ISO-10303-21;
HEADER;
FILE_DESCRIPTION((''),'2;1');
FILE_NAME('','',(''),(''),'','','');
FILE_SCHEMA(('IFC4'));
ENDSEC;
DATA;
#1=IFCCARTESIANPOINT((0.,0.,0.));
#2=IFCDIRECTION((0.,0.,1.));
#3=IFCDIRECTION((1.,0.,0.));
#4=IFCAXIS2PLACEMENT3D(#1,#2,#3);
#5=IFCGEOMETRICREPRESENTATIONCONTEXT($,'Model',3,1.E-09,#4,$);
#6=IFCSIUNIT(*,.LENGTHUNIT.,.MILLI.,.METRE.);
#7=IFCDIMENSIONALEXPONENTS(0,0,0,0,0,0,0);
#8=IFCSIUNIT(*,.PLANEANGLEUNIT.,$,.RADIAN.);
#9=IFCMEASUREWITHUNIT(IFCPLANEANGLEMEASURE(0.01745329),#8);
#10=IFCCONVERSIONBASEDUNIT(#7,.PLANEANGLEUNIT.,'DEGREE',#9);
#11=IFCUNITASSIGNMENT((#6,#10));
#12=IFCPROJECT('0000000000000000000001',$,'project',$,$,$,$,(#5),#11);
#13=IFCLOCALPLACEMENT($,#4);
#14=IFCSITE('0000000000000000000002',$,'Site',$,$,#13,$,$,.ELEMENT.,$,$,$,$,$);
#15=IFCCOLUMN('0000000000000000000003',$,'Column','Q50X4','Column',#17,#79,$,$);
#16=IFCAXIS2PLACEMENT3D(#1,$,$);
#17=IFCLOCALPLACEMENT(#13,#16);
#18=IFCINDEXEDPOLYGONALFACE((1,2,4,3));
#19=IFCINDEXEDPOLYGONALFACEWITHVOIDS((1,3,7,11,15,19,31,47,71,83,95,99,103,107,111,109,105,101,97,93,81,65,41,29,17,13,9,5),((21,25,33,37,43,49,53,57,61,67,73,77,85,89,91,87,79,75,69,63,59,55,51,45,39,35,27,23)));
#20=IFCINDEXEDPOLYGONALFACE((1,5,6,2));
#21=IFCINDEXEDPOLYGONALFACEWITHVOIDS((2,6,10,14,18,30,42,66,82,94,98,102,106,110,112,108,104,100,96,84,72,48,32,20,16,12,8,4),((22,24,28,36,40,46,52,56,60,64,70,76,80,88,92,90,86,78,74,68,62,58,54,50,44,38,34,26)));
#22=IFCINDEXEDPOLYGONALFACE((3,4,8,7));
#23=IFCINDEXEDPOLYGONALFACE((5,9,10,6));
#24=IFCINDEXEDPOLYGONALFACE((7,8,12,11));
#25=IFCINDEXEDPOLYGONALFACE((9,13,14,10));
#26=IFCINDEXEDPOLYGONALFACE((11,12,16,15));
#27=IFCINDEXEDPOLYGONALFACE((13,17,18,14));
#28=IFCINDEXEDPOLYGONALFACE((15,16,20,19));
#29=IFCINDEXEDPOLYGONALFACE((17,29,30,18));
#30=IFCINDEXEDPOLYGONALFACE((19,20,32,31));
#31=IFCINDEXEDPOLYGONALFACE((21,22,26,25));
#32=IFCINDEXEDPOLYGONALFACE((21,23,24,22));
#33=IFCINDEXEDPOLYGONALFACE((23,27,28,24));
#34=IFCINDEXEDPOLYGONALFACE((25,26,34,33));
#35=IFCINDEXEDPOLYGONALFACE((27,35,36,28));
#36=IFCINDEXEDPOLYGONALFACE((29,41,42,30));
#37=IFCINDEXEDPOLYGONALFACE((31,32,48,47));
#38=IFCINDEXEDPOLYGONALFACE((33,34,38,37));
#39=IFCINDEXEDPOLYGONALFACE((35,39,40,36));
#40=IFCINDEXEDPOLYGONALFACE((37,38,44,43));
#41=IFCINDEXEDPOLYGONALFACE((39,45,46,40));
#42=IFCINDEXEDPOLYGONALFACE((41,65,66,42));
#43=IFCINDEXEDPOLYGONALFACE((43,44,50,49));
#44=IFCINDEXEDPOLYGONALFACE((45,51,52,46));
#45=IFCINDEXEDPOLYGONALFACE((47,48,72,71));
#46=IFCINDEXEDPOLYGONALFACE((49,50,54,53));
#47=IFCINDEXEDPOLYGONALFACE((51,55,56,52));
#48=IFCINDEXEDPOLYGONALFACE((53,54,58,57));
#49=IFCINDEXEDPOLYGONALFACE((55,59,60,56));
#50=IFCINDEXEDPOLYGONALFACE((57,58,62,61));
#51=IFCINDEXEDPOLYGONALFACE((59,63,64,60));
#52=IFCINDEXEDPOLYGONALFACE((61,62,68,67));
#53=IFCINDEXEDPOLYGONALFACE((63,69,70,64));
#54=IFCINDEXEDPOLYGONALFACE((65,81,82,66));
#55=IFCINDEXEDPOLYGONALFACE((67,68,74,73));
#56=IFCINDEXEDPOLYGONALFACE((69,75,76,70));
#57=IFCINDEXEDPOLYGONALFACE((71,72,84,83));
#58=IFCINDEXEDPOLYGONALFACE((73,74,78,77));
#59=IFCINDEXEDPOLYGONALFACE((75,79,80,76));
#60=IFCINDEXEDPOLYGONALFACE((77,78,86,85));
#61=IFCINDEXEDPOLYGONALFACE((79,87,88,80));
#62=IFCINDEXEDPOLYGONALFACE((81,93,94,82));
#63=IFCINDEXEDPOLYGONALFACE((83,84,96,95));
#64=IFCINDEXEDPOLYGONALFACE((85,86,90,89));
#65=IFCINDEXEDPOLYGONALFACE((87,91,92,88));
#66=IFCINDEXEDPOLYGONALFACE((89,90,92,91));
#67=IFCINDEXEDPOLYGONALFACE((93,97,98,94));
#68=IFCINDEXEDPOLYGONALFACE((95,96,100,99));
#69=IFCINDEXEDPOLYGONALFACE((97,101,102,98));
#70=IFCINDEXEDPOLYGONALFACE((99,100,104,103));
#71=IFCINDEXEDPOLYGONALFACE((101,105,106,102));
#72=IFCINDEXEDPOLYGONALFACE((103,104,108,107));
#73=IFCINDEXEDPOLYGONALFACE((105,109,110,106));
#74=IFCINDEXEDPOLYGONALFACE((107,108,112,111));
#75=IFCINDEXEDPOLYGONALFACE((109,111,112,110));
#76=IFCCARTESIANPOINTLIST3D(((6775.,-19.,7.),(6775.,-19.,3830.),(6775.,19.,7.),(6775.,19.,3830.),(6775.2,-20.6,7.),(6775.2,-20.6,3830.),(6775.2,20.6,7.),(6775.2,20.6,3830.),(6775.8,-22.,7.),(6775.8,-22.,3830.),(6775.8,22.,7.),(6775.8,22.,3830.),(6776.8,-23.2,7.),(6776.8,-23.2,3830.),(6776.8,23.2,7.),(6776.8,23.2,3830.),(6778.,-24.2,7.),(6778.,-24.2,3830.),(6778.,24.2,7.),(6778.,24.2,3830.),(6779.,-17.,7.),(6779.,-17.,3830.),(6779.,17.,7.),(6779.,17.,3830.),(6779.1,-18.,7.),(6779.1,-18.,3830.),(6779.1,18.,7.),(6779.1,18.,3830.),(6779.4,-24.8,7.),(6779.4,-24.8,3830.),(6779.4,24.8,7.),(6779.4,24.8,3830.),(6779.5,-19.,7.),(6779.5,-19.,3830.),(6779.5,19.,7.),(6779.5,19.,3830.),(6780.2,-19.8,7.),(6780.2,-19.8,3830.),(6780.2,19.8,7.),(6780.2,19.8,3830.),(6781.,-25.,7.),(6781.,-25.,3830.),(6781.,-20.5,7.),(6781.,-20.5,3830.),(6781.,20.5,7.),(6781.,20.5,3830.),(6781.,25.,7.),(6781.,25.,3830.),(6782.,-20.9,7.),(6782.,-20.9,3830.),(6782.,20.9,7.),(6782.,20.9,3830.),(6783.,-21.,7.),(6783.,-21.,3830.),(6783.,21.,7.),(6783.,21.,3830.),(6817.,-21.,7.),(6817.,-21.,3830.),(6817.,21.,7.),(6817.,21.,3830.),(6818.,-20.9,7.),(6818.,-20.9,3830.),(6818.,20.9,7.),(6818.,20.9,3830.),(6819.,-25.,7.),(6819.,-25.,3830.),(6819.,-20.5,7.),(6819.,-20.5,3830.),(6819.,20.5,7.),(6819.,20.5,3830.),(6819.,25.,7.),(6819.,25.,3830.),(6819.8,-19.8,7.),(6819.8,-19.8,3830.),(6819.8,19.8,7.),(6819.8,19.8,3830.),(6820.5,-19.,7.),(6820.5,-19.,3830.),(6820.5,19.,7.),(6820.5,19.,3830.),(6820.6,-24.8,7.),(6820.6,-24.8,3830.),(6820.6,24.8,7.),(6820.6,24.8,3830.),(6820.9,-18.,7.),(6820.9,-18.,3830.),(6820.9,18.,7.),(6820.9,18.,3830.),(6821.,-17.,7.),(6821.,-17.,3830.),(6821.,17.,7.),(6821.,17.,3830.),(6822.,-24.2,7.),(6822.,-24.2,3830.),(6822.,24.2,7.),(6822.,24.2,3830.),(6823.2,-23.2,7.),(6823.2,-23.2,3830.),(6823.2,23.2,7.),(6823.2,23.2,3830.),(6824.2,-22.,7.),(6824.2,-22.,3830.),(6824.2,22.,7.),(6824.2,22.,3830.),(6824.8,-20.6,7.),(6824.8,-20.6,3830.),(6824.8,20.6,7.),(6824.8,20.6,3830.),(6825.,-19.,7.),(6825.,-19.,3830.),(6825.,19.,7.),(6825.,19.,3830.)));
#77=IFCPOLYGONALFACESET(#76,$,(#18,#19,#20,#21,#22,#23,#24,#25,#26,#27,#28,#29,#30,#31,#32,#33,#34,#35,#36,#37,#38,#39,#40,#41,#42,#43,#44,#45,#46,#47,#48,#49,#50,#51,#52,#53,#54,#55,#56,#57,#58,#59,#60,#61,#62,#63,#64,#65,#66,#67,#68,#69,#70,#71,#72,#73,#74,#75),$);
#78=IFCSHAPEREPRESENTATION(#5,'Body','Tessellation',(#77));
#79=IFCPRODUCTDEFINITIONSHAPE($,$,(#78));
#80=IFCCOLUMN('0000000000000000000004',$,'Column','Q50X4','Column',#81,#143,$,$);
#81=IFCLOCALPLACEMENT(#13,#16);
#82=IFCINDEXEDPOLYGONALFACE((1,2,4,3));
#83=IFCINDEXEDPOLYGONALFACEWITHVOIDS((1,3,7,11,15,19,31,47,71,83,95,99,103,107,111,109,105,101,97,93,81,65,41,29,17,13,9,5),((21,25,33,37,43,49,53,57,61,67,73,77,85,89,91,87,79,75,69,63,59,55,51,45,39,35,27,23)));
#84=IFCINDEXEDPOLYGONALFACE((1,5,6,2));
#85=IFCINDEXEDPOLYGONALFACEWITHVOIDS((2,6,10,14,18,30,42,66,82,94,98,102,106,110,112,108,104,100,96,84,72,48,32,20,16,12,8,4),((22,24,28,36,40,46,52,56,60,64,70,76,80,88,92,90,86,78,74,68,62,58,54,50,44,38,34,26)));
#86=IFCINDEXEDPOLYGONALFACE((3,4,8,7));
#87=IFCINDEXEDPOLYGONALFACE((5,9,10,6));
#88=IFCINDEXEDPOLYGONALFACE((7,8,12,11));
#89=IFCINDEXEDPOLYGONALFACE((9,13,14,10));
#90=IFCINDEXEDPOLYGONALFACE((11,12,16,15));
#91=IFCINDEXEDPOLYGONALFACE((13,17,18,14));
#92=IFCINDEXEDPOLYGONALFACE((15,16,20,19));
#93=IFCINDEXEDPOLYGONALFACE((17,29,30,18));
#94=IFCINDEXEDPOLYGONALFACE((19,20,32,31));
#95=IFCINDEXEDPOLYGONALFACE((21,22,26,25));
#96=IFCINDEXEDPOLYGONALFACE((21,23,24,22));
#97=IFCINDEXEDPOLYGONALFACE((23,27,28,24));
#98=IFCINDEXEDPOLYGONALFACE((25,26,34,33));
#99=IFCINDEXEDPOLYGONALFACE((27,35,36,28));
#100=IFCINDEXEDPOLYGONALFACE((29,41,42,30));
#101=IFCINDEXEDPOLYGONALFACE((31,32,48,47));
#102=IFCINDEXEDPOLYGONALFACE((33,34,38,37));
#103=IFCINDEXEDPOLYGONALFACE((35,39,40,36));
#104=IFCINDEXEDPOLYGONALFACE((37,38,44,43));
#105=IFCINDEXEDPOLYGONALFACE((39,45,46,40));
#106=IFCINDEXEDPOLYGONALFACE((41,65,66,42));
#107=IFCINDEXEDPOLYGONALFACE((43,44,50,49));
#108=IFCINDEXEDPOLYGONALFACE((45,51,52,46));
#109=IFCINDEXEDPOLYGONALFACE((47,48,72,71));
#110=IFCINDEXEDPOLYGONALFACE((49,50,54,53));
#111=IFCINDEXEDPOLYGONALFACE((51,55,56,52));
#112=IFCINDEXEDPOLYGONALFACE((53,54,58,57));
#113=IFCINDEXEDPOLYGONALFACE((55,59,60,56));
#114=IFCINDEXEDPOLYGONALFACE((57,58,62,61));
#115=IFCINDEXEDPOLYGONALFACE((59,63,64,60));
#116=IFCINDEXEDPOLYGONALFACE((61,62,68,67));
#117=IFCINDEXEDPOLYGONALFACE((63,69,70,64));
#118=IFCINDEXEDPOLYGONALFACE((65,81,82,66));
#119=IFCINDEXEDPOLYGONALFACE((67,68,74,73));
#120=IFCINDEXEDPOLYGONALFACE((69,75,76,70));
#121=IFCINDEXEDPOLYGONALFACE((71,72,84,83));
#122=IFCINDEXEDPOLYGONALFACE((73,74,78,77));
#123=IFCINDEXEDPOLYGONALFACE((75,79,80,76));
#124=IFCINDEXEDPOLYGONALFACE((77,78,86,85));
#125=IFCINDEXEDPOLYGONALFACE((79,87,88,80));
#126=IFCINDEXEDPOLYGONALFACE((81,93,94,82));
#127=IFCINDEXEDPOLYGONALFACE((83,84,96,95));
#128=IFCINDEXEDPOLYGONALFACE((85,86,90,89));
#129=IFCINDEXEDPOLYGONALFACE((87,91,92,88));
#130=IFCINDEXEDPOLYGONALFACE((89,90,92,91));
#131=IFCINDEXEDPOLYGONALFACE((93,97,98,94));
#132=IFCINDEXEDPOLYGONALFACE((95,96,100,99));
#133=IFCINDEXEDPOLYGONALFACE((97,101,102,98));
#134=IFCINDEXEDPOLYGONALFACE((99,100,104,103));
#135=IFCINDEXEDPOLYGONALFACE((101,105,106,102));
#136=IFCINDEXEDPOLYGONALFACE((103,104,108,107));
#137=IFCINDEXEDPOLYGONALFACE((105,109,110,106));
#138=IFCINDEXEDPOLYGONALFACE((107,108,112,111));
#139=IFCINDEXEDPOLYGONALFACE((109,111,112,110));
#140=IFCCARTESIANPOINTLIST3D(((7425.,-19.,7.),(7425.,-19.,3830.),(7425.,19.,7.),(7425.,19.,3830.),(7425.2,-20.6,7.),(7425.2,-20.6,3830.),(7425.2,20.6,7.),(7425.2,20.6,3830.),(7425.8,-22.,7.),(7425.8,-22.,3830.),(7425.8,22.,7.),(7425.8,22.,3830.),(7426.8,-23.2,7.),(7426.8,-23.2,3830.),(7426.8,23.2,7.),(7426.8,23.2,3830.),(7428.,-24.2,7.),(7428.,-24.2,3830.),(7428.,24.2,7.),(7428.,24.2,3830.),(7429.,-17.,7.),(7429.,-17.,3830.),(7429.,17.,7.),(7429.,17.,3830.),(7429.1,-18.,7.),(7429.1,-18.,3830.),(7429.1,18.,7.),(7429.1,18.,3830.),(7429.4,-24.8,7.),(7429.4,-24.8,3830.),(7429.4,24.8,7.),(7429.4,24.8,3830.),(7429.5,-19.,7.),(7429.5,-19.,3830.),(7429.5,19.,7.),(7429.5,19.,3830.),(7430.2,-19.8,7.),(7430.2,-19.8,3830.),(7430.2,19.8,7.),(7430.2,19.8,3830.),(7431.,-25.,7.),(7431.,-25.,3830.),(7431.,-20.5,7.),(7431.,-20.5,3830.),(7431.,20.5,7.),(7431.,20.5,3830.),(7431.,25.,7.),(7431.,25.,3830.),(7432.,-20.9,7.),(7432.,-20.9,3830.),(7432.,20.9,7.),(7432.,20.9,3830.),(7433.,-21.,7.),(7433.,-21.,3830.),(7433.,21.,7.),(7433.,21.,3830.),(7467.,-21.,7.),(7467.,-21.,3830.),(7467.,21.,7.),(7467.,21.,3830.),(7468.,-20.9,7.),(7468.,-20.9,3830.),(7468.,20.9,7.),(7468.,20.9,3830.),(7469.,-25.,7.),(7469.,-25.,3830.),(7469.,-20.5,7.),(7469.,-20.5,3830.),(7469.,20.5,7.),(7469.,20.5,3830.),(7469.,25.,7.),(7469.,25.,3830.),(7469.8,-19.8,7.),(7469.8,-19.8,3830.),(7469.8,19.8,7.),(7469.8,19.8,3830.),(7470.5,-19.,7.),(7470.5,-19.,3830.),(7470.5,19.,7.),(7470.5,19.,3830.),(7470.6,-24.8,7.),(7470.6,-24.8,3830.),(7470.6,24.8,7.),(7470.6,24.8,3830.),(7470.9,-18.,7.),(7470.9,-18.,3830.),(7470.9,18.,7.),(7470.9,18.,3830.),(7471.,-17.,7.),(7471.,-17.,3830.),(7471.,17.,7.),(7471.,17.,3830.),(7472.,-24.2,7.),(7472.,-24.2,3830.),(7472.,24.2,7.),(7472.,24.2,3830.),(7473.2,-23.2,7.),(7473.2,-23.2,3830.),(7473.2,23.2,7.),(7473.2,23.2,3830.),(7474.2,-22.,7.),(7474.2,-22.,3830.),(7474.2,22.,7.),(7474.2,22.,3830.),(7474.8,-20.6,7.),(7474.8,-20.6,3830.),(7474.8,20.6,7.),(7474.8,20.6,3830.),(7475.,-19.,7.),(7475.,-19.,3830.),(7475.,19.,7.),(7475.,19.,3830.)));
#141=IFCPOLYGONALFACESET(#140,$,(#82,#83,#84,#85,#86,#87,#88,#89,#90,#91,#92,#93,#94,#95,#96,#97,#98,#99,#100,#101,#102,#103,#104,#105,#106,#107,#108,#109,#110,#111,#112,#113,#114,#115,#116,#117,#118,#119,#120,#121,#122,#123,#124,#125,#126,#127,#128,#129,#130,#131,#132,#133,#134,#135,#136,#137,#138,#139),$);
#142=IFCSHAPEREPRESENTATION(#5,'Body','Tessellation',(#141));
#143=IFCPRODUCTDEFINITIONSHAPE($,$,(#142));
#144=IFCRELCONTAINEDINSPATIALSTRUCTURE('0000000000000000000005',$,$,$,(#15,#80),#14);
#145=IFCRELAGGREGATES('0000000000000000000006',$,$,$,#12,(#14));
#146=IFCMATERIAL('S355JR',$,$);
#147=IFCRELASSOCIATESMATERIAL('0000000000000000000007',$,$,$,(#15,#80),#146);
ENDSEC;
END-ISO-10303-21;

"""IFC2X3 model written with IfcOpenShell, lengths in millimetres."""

from ifc_helpers import new_model, entity, si_unit, converted_unit, frame, origin, origin_with_axes, origin_2d, place, context, project, spatial, hollow_rectangle, extrude, clip, halfspace, material, element, save


model = new_model("IFC2X3")

# Units and contexts
model_context = context("Model", 3, precision=1e-09, world=origin_with_axes())
ifc_project = project(units=[si_unit("LENGTHUNIT", "METRE", prefix="MILLI"), converted_unit("PLANEANGLEUNIT", "DEGREE", entity("IfcPlaneAngleMeasure", 0.01745329), si_unit("PLANEANGLEUNIT", "RADIAN"), dimensions=[0, 0, 0, 0, 0, 0, 0])], contexts=[model_context])

# Site
site_placement = place(None, origin_with_axes())
site = spatial("IfcSite", under=ifc_project, at=site_placement, Name="Site", CompositionType="ELEMENT")

# Columns
ifc_material = material(Name="S355JR")
column_1_placement = place(None, frame((6800.0, 0.0, -35.4), z_axis=(0.0, 0.0, -1.0), x_axis=(-1.0, 0.0, 0.0)))
element("IfcColumn", 1, at=column_1_placement, inside=site, material=ifc_material, Name="Column", Description="Q50X4", ObjectType="Column", context=model_context, shape_type="Clipping", body=[
    clip(extrude(hollow_rectangle(XDim=50.0, YDim=50.0, WallThickness=4.0, InnerFilletRadius=4.0, OuterFilletRadius=6.0, at=origin_2d()), origin(), (0.0, 0.0, -1.0), 3865.4), halfspace(frame((6800.0, 0.0, -42.4), z_axis=(0.0, 0.0, -1.0), x_axis=(-1.0, 0.0, 0.0)), True)),
])
column_2_placement = place(None, frame((7450.0, 0.0, -35.4), z_axis=(0.0, 0.0, -1.0), x_axis=(-1.0, 0.0, 0.0)))
element("IfcColumn", 2, at=column_2_placement, inside=site, material=ifc_material, Name="Column", Description="Q50X4", ObjectType="Column", context=model_context, shape_type="Clipping", body=[
    clip(extrude(hollow_rectangle(XDim=50.0, YDim=50.0, WallThickness=4.0, InnerFilletRadius=4.0, OuterFilletRadius=6.0, at=origin_2d()), origin(), (0.0, 0.0, -1.0), 3865.4), halfspace(frame((7450.0, 0.0, -42.4), z_axis=(0.0, 0.0, -1.0), x_axis=(-1.0, 0.0, 0.0)), True)),
])

save(model, "model.ifc")
